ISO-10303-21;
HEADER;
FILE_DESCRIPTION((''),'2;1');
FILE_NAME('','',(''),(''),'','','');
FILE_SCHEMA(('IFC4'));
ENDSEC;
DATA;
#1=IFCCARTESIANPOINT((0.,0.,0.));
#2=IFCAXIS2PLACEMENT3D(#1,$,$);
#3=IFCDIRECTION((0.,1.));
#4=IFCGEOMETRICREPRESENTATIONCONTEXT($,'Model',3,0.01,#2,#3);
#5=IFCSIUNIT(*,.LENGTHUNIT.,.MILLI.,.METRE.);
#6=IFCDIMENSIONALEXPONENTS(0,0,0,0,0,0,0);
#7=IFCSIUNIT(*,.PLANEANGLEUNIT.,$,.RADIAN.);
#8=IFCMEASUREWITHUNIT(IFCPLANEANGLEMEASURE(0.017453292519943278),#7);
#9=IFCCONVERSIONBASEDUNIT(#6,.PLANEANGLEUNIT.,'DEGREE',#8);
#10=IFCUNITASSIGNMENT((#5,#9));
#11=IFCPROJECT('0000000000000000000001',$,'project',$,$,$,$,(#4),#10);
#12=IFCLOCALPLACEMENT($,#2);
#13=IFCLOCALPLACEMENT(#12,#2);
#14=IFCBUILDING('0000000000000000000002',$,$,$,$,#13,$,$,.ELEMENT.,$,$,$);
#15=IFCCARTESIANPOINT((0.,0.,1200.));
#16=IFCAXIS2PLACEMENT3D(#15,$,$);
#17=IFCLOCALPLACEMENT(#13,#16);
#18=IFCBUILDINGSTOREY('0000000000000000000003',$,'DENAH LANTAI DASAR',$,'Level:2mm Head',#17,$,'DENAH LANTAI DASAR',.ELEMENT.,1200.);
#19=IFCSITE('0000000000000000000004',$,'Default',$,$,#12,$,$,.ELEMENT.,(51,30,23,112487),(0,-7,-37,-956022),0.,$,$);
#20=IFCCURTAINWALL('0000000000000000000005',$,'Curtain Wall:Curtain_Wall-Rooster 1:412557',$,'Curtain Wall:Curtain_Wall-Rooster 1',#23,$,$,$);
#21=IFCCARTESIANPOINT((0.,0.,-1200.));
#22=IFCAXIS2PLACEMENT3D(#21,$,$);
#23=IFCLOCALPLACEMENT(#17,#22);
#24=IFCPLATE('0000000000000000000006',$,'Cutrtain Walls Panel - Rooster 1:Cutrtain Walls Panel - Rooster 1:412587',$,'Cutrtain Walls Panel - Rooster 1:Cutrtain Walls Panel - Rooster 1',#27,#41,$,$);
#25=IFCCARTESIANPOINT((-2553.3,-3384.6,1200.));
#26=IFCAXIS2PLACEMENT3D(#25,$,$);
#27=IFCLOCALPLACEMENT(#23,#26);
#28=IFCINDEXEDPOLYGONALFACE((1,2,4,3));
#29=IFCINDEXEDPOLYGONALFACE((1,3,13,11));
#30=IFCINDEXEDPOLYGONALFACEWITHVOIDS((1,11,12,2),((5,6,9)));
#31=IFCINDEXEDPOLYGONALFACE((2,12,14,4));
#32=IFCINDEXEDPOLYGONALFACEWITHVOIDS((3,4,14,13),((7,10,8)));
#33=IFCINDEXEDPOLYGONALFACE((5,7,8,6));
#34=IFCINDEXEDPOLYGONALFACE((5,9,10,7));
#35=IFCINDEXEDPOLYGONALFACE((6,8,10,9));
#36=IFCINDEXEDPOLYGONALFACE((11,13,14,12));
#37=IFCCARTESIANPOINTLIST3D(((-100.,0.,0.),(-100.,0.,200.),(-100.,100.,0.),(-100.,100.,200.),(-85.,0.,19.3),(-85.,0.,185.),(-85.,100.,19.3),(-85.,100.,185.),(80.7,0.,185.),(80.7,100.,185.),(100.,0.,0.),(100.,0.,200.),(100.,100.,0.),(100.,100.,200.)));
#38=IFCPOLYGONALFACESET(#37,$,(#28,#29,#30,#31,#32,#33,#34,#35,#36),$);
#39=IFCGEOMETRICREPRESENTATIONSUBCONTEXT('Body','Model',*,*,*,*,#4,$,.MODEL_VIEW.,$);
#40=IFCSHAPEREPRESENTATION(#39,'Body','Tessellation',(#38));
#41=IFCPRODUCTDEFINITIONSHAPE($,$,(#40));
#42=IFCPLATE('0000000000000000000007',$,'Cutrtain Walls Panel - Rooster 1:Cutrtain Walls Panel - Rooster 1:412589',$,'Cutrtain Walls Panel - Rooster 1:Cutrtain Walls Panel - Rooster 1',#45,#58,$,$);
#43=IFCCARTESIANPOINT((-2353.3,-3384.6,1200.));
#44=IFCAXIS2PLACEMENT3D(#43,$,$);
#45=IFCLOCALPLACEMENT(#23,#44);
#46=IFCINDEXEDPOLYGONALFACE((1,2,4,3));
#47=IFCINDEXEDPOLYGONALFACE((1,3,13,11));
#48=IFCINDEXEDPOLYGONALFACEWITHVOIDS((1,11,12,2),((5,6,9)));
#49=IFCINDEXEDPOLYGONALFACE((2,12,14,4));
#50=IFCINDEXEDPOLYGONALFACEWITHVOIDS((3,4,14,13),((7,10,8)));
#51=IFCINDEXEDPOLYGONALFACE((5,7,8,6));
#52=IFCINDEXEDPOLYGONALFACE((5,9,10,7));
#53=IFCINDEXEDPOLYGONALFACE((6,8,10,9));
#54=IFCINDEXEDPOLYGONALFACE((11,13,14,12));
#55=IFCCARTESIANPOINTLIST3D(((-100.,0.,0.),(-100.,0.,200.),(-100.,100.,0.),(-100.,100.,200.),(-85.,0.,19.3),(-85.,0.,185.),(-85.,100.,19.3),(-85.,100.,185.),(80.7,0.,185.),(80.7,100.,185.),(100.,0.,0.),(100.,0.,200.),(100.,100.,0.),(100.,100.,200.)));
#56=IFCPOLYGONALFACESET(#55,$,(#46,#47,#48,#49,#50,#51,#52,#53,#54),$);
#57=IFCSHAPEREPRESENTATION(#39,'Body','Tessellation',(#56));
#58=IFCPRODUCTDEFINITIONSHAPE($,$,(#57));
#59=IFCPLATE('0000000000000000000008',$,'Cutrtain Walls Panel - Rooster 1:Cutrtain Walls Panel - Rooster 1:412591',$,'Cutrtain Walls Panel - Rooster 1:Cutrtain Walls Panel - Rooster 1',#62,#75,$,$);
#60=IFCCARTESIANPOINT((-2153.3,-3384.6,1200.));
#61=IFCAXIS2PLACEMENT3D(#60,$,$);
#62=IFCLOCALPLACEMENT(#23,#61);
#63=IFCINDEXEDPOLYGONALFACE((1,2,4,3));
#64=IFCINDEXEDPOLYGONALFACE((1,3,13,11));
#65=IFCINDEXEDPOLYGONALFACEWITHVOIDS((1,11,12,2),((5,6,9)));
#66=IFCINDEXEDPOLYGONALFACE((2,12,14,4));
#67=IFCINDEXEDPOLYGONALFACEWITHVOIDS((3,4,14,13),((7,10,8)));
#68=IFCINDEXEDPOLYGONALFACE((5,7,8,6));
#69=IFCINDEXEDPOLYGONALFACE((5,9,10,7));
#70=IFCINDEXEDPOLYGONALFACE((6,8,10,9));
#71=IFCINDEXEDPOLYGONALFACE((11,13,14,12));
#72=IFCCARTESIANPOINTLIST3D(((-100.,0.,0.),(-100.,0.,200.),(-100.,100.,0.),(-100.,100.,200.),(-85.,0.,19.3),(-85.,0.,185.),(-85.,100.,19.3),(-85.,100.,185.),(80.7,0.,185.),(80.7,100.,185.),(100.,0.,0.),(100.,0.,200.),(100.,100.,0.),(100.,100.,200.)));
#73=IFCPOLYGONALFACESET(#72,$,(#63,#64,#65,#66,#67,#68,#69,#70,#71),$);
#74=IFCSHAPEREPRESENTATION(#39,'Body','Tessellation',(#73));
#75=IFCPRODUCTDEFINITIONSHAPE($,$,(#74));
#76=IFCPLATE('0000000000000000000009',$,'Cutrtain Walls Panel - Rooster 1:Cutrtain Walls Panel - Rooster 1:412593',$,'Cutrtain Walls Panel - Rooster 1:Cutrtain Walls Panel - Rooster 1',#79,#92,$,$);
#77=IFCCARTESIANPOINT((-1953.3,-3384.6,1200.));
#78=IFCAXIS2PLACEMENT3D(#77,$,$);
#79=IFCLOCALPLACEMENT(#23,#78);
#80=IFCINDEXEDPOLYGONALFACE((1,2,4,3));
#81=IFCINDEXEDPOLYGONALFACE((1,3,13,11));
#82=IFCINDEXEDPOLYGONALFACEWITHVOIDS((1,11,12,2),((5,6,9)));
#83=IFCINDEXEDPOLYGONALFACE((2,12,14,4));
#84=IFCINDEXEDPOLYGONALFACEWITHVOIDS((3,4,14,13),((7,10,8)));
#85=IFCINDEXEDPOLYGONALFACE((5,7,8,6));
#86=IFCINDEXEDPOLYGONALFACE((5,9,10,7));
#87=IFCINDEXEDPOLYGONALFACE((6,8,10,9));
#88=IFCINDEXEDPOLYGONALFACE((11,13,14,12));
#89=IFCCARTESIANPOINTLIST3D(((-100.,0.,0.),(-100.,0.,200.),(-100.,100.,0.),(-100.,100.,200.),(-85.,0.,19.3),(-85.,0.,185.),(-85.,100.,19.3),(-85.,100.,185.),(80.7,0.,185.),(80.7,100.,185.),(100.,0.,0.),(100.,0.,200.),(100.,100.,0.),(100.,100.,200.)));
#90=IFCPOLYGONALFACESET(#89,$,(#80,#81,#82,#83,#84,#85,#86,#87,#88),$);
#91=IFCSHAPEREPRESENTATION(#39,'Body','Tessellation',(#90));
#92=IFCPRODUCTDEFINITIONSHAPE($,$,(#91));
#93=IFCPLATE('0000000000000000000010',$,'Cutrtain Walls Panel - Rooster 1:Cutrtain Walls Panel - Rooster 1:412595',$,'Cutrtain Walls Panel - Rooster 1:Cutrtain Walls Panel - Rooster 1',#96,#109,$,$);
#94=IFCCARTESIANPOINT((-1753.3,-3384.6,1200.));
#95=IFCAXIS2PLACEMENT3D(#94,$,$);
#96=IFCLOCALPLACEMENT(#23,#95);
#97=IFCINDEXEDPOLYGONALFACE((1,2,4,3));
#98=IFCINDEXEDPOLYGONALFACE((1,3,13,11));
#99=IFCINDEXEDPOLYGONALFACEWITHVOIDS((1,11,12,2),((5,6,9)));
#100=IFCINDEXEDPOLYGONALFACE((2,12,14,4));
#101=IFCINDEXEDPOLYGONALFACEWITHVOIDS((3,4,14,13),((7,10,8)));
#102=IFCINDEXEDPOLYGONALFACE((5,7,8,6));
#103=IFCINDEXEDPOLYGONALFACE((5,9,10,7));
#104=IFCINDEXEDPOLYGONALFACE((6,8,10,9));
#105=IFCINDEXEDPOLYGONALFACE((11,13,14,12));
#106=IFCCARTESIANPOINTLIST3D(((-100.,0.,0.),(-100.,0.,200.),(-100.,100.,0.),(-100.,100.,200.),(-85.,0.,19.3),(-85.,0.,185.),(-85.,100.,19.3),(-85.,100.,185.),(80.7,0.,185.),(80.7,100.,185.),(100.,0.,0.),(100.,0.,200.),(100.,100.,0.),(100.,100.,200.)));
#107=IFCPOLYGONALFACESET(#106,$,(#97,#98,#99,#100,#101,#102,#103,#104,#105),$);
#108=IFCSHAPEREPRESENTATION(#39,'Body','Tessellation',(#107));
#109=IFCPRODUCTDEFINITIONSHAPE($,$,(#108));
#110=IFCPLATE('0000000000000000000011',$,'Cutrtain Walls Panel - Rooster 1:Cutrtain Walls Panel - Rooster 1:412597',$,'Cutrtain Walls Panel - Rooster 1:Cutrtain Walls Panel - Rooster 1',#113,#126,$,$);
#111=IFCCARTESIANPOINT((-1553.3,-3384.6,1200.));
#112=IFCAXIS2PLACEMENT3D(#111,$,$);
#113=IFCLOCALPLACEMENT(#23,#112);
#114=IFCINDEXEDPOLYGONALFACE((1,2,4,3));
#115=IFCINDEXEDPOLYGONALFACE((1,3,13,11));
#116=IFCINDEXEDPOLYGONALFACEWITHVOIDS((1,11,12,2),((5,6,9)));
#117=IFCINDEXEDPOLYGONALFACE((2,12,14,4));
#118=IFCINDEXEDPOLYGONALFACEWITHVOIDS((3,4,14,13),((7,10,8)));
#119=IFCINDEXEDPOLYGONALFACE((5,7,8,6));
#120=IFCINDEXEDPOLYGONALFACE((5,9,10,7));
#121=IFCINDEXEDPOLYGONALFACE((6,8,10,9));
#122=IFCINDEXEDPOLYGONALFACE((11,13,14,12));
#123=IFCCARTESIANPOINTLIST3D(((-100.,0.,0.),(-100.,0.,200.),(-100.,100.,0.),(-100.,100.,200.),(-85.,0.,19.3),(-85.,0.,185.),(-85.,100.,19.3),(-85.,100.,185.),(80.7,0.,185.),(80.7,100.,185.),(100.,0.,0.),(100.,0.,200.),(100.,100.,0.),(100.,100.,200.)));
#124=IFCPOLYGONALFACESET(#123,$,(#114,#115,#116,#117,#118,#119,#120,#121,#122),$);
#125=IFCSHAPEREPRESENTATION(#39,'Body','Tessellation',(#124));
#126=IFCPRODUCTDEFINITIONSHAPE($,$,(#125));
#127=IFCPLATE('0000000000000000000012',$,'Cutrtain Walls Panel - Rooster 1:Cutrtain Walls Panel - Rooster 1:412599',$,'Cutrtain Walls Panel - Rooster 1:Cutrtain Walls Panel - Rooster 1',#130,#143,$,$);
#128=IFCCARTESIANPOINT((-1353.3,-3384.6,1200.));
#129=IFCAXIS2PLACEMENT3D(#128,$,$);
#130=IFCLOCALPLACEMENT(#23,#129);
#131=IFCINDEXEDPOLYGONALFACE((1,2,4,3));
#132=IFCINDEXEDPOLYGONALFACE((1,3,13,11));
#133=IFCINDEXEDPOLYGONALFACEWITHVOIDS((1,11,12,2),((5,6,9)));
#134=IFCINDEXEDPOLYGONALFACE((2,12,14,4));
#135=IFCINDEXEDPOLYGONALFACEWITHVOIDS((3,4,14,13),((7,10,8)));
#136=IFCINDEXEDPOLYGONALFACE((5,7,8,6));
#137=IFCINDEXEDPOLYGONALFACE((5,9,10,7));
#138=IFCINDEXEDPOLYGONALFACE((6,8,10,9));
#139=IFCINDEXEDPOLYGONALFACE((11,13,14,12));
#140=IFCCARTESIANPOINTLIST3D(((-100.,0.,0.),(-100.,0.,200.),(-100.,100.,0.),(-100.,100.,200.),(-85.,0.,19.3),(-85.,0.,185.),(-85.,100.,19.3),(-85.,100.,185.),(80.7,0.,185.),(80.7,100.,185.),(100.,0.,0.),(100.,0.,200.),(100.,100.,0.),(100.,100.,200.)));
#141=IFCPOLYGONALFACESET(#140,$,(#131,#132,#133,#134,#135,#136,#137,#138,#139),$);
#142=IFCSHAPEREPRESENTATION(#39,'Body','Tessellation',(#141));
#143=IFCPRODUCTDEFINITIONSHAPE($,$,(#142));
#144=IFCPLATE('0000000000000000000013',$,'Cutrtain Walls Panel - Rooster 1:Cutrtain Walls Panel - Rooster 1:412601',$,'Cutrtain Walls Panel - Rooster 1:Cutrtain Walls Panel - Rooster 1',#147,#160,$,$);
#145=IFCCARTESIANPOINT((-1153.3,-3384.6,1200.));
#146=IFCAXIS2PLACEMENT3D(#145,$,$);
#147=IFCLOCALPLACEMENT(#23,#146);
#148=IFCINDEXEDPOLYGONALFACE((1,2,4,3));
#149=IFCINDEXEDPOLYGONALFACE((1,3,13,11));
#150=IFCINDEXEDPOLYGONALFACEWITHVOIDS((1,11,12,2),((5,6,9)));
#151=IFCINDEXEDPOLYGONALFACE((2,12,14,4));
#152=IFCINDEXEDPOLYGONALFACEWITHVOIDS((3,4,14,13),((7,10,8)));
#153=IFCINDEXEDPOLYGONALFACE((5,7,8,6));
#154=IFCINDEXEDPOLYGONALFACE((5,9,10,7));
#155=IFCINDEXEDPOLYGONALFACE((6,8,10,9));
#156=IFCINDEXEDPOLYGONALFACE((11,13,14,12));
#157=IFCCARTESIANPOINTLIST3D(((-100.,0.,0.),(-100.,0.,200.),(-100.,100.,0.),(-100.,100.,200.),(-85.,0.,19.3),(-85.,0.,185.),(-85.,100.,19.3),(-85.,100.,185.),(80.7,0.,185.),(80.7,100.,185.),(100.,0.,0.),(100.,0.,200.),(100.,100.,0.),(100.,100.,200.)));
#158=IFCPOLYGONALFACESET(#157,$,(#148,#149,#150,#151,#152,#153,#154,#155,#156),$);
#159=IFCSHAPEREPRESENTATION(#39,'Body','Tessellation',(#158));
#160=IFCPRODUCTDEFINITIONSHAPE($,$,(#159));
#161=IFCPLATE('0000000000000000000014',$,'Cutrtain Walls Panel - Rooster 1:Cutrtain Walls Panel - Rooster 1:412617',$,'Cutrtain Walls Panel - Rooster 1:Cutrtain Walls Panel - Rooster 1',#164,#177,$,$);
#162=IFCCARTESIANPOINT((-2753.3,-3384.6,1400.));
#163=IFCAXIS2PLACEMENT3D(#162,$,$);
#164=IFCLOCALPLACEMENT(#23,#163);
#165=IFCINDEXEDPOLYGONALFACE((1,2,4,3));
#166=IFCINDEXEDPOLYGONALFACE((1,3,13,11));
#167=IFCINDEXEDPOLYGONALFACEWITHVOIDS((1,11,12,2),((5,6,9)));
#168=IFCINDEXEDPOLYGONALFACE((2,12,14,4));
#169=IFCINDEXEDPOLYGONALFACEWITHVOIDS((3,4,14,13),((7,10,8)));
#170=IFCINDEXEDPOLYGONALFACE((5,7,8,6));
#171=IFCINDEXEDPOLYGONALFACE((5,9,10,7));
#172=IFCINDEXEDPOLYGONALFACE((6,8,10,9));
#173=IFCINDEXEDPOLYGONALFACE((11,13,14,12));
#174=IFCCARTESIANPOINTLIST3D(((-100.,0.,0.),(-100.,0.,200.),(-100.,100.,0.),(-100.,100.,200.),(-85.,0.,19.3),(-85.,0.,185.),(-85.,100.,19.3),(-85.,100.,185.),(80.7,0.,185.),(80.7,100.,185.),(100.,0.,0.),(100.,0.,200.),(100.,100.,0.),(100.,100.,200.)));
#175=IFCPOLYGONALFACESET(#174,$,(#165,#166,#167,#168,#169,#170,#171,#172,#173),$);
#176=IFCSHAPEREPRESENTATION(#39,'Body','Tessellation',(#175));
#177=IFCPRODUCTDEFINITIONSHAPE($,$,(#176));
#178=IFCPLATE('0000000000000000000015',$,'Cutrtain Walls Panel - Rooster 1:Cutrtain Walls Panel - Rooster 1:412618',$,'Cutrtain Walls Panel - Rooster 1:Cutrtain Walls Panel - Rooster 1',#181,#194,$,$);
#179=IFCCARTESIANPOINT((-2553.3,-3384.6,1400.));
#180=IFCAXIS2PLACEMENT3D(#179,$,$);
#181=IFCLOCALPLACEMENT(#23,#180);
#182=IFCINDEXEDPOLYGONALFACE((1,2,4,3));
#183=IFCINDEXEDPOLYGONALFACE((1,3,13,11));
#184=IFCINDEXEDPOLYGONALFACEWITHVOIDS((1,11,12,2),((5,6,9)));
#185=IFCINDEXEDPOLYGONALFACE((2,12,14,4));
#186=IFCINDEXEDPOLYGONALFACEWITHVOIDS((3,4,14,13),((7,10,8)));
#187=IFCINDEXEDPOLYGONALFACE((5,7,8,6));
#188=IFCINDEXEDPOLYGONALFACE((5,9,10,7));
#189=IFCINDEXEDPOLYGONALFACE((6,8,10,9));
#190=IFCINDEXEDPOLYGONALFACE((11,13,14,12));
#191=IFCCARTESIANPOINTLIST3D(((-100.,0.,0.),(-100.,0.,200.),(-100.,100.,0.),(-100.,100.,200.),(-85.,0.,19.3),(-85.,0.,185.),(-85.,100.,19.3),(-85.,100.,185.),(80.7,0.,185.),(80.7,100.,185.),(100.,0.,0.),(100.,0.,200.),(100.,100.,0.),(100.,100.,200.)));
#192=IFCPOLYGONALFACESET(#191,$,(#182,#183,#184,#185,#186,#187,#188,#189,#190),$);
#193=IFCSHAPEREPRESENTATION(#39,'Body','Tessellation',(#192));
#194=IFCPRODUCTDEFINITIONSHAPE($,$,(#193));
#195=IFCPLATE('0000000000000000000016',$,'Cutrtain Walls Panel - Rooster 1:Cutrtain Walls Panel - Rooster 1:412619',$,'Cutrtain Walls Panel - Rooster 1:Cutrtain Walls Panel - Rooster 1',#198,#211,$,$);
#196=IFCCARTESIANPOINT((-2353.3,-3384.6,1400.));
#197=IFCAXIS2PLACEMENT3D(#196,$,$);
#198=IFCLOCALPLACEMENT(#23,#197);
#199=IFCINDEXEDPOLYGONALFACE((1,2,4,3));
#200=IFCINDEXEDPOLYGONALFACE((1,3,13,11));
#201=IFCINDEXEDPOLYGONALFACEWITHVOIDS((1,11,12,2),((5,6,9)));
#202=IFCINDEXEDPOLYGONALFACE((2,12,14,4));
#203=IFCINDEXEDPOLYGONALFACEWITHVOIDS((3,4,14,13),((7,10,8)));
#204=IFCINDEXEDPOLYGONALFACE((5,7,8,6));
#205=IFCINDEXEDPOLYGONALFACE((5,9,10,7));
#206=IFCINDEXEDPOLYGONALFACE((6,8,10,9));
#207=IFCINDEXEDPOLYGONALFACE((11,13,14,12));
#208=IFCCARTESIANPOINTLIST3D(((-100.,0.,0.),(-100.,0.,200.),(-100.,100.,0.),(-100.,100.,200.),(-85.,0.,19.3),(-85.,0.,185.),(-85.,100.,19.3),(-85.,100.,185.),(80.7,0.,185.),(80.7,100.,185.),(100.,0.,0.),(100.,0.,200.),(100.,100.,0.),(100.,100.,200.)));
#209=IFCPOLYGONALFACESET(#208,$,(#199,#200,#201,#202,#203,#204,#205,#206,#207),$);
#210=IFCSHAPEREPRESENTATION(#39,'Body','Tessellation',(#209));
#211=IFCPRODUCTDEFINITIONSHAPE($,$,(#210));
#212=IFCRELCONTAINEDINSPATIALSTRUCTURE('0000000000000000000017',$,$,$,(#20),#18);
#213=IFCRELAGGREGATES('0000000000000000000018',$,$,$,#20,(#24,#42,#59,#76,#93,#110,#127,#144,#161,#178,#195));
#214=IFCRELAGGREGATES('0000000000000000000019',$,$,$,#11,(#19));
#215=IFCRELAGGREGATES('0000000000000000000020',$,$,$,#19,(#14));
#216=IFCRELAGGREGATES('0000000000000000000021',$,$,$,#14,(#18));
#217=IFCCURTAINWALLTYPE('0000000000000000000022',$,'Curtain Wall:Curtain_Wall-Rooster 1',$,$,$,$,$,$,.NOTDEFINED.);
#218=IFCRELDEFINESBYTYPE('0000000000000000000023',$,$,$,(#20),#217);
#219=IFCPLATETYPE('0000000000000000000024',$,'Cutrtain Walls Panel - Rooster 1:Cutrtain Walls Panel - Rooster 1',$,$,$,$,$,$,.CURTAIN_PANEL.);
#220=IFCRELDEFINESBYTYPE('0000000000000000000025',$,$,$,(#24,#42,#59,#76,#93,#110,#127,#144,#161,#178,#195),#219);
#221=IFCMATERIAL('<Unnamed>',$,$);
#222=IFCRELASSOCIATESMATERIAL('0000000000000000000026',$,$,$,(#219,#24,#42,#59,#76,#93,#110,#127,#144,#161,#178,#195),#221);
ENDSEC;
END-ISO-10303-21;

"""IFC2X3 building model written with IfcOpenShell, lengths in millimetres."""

from ifc_helpers import new_model, entity, si_unit, converted_unit, direction, frame, origin, place, context, subcontext, project, spatial, polyline, outline, extrude, source, transform, mapped, material, type_object, type_shapes, element, aggregate, save


model = new_model("IFC2X3")

# Units and contexts
model_context = context("Model", 3, precision=0.01, world=origin(), true_north=direction((0.0, 1.0)))
body_context = subcontext(model_context, "Body", "Model", "MODEL_VIEW")
ifc_project = project(units=[si_unit("LENGTHUNIT", "METRE", prefix="MILLI"), converted_unit("PLANEANGLEUNIT", "DEGREE", entity("IfcPlaneAngleMeasure", 0.017453292519943278), si_unit("PLANEANGLEUNIT", "RADIAN"), dimensions=[0, 0, 0, 0, 0, 0, 0])], contexts=[model_context])

# Site, building, storey
site_placement = place(None, origin())
site = spatial("IfcSite", under=ifc_project, at=site_placement, Name="Default", CompositionType="ELEMENT", RefLatitude=(51, 30, 23, 112487), RefLongitude=(0, -7, -37, -956022), RefElevation=0.0)
building_placement = place(site_placement, origin())
building = spatial("IfcBuilding", under=site, at=building_placement, CompositionType="ELEMENT")
storey_placement = place(building_placement, frame((0.0, 0.0, 1200.0)))
storey = spatial("IfcBuildingStorey", under=building, at=storey_placement, Name="DENAH LANTAI DASAR", ObjectType="Level:2mm Head", LongName="DENAH LANTAI DASAR", CompositionType="ELEMENT", Elevation=1200.0)

# Curtain wall, plates
curtain_wall_type = type_object("IfcCurtainWallType", Name="Curtain Wall:Curtain_Wall-Rooster 1", PredefinedType="NOTDEFINED")
curtain_wall_1_placement = place(storey_placement, frame((0.0, 0.0, -1200.0)))
curtain_wall_1 = element("IfcCurtainWall", 1, at=curtain_wall_1_placement, inside=storey, type_object=curtain_wall_type, Name="Curtain Wall:Curtain_Wall-Rooster 1:412557", ObjectType="Curtain Wall:Curtain_Wall-Rooster 1")
ifc_material = material(Name="<Unnamed>")
plate_type_1 = type_object("IfcPlateType", Name="Cutrtain Walls Panel - Rooster 1:Cutrtain Walls Panel - Rooster 1", PredefinedType="CURTAIN_PANEL", material=ifc_material)
shared_shape_1 = source(origin(), body_context, "Body", "SweptSolid", [
    extrude(outline(polyline([(-100.0, -100.0), (100.0, -100.0), (100.0, 100.0), (-100.0, 100.0), (-100.0, -100.0)]), holes=[polyline([(80.7, 85.0), (-85.0, -80.7), (-85.0, 85.0), (80.7, 85.0)])]), frame((0.0, 0.0, 100.0), z_axis=(0.0, 1.0, 0.0), x_axis=(0.0, 0.0, -1.0)), (0.0, 0.0, 1.0), 100.0),
])
type_shapes(plate_type_1, [shared_shape_1])
plate_1_placement = place(curtain_wall_1_placement, frame((-2553.3, -3384.6, 1200.0)))
plate_1 = element("IfcPlate", 2, at=plate_1_placement, type_object=plate_type_1, material=ifc_material, Name="Cutrtain Walls Panel - Rooster 1:Cutrtain Walls Panel - Rooster 1:412587", ObjectType="Cutrtain Walls Panel - Rooster 1:Cutrtain Walls Panel - Rooster 1", context=body_context, shape_type="MappedRepresentation", body=[
    mapped(shared_shape_1, transform((0.0, 0.0, 0.0), scale=1.0)),
])
plate_2_placement = place(curtain_wall_1_placement, frame((-2353.3, -3384.6, 1200.0)))
plate_2 = element("IfcPlate", 3, at=plate_2_placement, type_object=plate_type_1, material=ifc_material, Name="Cutrtain Walls Panel - Rooster 1:Cutrtain Walls Panel - Rooster 1:412589", ObjectType="Cutrtain Walls Panel - Rooster 1:Cutrtain Walls Panel - Rooster 1", context=body_context, shape_type="MappedRepresentation", body=[
    mapped(shared_shape_1, transform((0.0, 0.0, 0.0), scale=1.0)),
])
plate_3_placement = place(curtain_wall_1_placement, frame((-2153.3, -3384.6, 1200.0)))
plate_3 = element("IfcPlate", 4, at=plate_3_placement, type_object=plate_type_1, material=ifc_material, Name="Cutrtain Walls Panel - Rooster 1:Cutrtain Walls Panel - Rooster 1:412591", ObjectType="Cutrtain Walls Panel - Rooster 1:Cutrtain Walls Panel - Rooster 1", context=body_context, shape_type="MappedRepresentation", body=[
    mapped(shared_shape_1, transform((0.0, 0.0, 0.0), scale=1.0)),
])
plate_4_placement = place(curtain_wall_1_placement, frame((-1953.3, -3384.6, 1200.0)))
plate_4 = element("IfcPlate", 5, at=plate_4_placement, type_object=plate_type_1, material=ifc_material, Name="Cutrtain Walls Panel - Rooster 1:Cutrtain Walls Panel - Rooster 1:412593", ObjectType="Cutrtain Walls Panel - Rooster 1:Cutrtain Walls Panel - Rooster 1", context=body_context, shape_type="MappedRepresentation", body=[
    mapped(shared_shape_1, transform((0.0, 0.0, 0.0), scale=1.0)),
])
plate_5_placement = place(curtain_wall_1_placement, frame((-1753.3, -3384.6, 1200.0)))
plate_5 = element("IfcPlate", 6, at=plate_5_placement, type_object=plate_type_1, material=ifc_material, Name="Cutrtain Walls Panel - Rooster 1:Cutrtain Walls Panel - Rooster 1:412595", ObjectType="Cutrtain Walls Panel - Rooster 1:Cutrtain Walls Panel - Rooster 1", context=body_context, shape_type="MappedRepresentation", body=[
    mapped(shared_shape_1, transform((0.0, 0.0, 0.0), scale=1.0)),
])
plate_6_placement = place(curtain_wall_1_placement, frame((-1553.3, -3384.6, 1200.0)))
plate_6 = element("IfcPlate", 7, at=plate_6_placement, type_object=plate_type_1, material=ifc_material, Name="Cutrtain Walls Panel - Rooster 1:Cutrtain Walls Panel - Rooster 1:412597", ObjectType="Cutrtain Walls Panel - Rooster 1:Cutrtain Walls Panel - Rooster 1", context=body_context, shape_type="MappedRepresentation", body=[
    mapped(shared_shape_1, transform((0.0, 0.0, 0.0), scale=1.0)),
])
plate_7_placement = place(curtain_wall_1_placement, frame((-1353.3, -3384.6, 1200.0)))
plate_7 = element("IfcPlate", 8, at=plate_7_placement, type_object=plate_type_1, material=ifc_material, Name="Cutrtain Walls Panel - Rooster 1:Cutrtain Walls Panel - Rooster 1:412599", ObjectType="Cutrtain Walls Panel - Rooster 1:Cutrtain Walls Panel - Rooster 1", context=body_context, shape_type="MappedRepresentation", body=[
    mapped(shared_shape_1, transform((0.0, 0.0, 0.0), scale=1.0)),
])
plate_8_placement = place(curtain_wall_1_placement, frame((-1153.3, -3384.6, 1200.0)))
plate_8 = element("IfcPlate", 9, at=plate_8_placement, type_object=plate_type_1, material=ifc_material, Name="Cutrtain Walls Panel - Rooster 1:Cutrtain Walls Panel - Rooster 1:412601", ObjectType="Cutrtain Walls Panel - Rooster 1:Cutrtain Walls Panel - Rooster 1", context=body_context, shape_type="MappedRepresentation", body=[
    mapped(shared_shape_1, transform((0.0, 0.0, 0.0), scale=1.0)),
])
plate_9_placement = place(curtain_wall_1_placement, frame((-2753.3, -3384.6, 1400.0)))
plate_9 = element("IfcPlate", 10, at=plate_9_placement, type_object=plate_type_1, material=ifc_material, Name="Cutrtain Walls Panel - Rooster 1:Cutrtain Walls Panel - Rooster 1:412617", ObjectType="Cutrtain Walls Panel - Rooster 1:Cutrtain Walls Panel - Rooster 1", context=body_context, shape_type="MappedRepresentation", body=[
    mapped(shared_shape_1, transform((0.0, 0.0, 0.0), scale=1.0)),
])
plate_10_placement = place(curtain_wall_1_placement, frame((-2553.3, -3384.6, 1400.0)))
plate_10 = element("IfcPlate", 11, at=plate_10_placement, type_object=plate_type_1, material=ifc_material, Name="Cutrtain Walls Panel - Rooster 1:Cutrtain Walls Panel - Rooster 1:412618", ObjectType="Cutrtain Walls Panel - Rooster 1:Cutrtain Walls Panel - Rooster 1", context=body_context, shape_type="MappedRepresentation", body=[
    mapped(shared_shape_1, transform((0.0, 0.0, 0.0), scale=1.0)),
])
plate_11_placement = place(curtain_wall_1_placement, frame((-2353.3, -3384.6, 1400.0)))
plate_11 = element("IfcPlate", 12, at=plate_11_placement, type_object=plate_type_1, material=ifc_material, Name="Cutrtain Walls Panel - Rooster 1:Cutrtain Walls Panel - Rooster 1:412619", ObjectType="Cutrtain Walls Panel - Rooster 1:Cutrtain Walls Panel - Rooster 1", context=body_context, shape_type="MappedRepresentation", body=[
    mapped(shared_shape_1, transform((0.0, 0.0, 0.0), scale=1.0)),
])
aggregate(curtain_wall_1, [plate_1, plate_2, plate_3, plate_4, plate_5, plate_6, plate_7, plate_8, plate_9, plate_10, plate_11])

save(model, "model.ifc")
